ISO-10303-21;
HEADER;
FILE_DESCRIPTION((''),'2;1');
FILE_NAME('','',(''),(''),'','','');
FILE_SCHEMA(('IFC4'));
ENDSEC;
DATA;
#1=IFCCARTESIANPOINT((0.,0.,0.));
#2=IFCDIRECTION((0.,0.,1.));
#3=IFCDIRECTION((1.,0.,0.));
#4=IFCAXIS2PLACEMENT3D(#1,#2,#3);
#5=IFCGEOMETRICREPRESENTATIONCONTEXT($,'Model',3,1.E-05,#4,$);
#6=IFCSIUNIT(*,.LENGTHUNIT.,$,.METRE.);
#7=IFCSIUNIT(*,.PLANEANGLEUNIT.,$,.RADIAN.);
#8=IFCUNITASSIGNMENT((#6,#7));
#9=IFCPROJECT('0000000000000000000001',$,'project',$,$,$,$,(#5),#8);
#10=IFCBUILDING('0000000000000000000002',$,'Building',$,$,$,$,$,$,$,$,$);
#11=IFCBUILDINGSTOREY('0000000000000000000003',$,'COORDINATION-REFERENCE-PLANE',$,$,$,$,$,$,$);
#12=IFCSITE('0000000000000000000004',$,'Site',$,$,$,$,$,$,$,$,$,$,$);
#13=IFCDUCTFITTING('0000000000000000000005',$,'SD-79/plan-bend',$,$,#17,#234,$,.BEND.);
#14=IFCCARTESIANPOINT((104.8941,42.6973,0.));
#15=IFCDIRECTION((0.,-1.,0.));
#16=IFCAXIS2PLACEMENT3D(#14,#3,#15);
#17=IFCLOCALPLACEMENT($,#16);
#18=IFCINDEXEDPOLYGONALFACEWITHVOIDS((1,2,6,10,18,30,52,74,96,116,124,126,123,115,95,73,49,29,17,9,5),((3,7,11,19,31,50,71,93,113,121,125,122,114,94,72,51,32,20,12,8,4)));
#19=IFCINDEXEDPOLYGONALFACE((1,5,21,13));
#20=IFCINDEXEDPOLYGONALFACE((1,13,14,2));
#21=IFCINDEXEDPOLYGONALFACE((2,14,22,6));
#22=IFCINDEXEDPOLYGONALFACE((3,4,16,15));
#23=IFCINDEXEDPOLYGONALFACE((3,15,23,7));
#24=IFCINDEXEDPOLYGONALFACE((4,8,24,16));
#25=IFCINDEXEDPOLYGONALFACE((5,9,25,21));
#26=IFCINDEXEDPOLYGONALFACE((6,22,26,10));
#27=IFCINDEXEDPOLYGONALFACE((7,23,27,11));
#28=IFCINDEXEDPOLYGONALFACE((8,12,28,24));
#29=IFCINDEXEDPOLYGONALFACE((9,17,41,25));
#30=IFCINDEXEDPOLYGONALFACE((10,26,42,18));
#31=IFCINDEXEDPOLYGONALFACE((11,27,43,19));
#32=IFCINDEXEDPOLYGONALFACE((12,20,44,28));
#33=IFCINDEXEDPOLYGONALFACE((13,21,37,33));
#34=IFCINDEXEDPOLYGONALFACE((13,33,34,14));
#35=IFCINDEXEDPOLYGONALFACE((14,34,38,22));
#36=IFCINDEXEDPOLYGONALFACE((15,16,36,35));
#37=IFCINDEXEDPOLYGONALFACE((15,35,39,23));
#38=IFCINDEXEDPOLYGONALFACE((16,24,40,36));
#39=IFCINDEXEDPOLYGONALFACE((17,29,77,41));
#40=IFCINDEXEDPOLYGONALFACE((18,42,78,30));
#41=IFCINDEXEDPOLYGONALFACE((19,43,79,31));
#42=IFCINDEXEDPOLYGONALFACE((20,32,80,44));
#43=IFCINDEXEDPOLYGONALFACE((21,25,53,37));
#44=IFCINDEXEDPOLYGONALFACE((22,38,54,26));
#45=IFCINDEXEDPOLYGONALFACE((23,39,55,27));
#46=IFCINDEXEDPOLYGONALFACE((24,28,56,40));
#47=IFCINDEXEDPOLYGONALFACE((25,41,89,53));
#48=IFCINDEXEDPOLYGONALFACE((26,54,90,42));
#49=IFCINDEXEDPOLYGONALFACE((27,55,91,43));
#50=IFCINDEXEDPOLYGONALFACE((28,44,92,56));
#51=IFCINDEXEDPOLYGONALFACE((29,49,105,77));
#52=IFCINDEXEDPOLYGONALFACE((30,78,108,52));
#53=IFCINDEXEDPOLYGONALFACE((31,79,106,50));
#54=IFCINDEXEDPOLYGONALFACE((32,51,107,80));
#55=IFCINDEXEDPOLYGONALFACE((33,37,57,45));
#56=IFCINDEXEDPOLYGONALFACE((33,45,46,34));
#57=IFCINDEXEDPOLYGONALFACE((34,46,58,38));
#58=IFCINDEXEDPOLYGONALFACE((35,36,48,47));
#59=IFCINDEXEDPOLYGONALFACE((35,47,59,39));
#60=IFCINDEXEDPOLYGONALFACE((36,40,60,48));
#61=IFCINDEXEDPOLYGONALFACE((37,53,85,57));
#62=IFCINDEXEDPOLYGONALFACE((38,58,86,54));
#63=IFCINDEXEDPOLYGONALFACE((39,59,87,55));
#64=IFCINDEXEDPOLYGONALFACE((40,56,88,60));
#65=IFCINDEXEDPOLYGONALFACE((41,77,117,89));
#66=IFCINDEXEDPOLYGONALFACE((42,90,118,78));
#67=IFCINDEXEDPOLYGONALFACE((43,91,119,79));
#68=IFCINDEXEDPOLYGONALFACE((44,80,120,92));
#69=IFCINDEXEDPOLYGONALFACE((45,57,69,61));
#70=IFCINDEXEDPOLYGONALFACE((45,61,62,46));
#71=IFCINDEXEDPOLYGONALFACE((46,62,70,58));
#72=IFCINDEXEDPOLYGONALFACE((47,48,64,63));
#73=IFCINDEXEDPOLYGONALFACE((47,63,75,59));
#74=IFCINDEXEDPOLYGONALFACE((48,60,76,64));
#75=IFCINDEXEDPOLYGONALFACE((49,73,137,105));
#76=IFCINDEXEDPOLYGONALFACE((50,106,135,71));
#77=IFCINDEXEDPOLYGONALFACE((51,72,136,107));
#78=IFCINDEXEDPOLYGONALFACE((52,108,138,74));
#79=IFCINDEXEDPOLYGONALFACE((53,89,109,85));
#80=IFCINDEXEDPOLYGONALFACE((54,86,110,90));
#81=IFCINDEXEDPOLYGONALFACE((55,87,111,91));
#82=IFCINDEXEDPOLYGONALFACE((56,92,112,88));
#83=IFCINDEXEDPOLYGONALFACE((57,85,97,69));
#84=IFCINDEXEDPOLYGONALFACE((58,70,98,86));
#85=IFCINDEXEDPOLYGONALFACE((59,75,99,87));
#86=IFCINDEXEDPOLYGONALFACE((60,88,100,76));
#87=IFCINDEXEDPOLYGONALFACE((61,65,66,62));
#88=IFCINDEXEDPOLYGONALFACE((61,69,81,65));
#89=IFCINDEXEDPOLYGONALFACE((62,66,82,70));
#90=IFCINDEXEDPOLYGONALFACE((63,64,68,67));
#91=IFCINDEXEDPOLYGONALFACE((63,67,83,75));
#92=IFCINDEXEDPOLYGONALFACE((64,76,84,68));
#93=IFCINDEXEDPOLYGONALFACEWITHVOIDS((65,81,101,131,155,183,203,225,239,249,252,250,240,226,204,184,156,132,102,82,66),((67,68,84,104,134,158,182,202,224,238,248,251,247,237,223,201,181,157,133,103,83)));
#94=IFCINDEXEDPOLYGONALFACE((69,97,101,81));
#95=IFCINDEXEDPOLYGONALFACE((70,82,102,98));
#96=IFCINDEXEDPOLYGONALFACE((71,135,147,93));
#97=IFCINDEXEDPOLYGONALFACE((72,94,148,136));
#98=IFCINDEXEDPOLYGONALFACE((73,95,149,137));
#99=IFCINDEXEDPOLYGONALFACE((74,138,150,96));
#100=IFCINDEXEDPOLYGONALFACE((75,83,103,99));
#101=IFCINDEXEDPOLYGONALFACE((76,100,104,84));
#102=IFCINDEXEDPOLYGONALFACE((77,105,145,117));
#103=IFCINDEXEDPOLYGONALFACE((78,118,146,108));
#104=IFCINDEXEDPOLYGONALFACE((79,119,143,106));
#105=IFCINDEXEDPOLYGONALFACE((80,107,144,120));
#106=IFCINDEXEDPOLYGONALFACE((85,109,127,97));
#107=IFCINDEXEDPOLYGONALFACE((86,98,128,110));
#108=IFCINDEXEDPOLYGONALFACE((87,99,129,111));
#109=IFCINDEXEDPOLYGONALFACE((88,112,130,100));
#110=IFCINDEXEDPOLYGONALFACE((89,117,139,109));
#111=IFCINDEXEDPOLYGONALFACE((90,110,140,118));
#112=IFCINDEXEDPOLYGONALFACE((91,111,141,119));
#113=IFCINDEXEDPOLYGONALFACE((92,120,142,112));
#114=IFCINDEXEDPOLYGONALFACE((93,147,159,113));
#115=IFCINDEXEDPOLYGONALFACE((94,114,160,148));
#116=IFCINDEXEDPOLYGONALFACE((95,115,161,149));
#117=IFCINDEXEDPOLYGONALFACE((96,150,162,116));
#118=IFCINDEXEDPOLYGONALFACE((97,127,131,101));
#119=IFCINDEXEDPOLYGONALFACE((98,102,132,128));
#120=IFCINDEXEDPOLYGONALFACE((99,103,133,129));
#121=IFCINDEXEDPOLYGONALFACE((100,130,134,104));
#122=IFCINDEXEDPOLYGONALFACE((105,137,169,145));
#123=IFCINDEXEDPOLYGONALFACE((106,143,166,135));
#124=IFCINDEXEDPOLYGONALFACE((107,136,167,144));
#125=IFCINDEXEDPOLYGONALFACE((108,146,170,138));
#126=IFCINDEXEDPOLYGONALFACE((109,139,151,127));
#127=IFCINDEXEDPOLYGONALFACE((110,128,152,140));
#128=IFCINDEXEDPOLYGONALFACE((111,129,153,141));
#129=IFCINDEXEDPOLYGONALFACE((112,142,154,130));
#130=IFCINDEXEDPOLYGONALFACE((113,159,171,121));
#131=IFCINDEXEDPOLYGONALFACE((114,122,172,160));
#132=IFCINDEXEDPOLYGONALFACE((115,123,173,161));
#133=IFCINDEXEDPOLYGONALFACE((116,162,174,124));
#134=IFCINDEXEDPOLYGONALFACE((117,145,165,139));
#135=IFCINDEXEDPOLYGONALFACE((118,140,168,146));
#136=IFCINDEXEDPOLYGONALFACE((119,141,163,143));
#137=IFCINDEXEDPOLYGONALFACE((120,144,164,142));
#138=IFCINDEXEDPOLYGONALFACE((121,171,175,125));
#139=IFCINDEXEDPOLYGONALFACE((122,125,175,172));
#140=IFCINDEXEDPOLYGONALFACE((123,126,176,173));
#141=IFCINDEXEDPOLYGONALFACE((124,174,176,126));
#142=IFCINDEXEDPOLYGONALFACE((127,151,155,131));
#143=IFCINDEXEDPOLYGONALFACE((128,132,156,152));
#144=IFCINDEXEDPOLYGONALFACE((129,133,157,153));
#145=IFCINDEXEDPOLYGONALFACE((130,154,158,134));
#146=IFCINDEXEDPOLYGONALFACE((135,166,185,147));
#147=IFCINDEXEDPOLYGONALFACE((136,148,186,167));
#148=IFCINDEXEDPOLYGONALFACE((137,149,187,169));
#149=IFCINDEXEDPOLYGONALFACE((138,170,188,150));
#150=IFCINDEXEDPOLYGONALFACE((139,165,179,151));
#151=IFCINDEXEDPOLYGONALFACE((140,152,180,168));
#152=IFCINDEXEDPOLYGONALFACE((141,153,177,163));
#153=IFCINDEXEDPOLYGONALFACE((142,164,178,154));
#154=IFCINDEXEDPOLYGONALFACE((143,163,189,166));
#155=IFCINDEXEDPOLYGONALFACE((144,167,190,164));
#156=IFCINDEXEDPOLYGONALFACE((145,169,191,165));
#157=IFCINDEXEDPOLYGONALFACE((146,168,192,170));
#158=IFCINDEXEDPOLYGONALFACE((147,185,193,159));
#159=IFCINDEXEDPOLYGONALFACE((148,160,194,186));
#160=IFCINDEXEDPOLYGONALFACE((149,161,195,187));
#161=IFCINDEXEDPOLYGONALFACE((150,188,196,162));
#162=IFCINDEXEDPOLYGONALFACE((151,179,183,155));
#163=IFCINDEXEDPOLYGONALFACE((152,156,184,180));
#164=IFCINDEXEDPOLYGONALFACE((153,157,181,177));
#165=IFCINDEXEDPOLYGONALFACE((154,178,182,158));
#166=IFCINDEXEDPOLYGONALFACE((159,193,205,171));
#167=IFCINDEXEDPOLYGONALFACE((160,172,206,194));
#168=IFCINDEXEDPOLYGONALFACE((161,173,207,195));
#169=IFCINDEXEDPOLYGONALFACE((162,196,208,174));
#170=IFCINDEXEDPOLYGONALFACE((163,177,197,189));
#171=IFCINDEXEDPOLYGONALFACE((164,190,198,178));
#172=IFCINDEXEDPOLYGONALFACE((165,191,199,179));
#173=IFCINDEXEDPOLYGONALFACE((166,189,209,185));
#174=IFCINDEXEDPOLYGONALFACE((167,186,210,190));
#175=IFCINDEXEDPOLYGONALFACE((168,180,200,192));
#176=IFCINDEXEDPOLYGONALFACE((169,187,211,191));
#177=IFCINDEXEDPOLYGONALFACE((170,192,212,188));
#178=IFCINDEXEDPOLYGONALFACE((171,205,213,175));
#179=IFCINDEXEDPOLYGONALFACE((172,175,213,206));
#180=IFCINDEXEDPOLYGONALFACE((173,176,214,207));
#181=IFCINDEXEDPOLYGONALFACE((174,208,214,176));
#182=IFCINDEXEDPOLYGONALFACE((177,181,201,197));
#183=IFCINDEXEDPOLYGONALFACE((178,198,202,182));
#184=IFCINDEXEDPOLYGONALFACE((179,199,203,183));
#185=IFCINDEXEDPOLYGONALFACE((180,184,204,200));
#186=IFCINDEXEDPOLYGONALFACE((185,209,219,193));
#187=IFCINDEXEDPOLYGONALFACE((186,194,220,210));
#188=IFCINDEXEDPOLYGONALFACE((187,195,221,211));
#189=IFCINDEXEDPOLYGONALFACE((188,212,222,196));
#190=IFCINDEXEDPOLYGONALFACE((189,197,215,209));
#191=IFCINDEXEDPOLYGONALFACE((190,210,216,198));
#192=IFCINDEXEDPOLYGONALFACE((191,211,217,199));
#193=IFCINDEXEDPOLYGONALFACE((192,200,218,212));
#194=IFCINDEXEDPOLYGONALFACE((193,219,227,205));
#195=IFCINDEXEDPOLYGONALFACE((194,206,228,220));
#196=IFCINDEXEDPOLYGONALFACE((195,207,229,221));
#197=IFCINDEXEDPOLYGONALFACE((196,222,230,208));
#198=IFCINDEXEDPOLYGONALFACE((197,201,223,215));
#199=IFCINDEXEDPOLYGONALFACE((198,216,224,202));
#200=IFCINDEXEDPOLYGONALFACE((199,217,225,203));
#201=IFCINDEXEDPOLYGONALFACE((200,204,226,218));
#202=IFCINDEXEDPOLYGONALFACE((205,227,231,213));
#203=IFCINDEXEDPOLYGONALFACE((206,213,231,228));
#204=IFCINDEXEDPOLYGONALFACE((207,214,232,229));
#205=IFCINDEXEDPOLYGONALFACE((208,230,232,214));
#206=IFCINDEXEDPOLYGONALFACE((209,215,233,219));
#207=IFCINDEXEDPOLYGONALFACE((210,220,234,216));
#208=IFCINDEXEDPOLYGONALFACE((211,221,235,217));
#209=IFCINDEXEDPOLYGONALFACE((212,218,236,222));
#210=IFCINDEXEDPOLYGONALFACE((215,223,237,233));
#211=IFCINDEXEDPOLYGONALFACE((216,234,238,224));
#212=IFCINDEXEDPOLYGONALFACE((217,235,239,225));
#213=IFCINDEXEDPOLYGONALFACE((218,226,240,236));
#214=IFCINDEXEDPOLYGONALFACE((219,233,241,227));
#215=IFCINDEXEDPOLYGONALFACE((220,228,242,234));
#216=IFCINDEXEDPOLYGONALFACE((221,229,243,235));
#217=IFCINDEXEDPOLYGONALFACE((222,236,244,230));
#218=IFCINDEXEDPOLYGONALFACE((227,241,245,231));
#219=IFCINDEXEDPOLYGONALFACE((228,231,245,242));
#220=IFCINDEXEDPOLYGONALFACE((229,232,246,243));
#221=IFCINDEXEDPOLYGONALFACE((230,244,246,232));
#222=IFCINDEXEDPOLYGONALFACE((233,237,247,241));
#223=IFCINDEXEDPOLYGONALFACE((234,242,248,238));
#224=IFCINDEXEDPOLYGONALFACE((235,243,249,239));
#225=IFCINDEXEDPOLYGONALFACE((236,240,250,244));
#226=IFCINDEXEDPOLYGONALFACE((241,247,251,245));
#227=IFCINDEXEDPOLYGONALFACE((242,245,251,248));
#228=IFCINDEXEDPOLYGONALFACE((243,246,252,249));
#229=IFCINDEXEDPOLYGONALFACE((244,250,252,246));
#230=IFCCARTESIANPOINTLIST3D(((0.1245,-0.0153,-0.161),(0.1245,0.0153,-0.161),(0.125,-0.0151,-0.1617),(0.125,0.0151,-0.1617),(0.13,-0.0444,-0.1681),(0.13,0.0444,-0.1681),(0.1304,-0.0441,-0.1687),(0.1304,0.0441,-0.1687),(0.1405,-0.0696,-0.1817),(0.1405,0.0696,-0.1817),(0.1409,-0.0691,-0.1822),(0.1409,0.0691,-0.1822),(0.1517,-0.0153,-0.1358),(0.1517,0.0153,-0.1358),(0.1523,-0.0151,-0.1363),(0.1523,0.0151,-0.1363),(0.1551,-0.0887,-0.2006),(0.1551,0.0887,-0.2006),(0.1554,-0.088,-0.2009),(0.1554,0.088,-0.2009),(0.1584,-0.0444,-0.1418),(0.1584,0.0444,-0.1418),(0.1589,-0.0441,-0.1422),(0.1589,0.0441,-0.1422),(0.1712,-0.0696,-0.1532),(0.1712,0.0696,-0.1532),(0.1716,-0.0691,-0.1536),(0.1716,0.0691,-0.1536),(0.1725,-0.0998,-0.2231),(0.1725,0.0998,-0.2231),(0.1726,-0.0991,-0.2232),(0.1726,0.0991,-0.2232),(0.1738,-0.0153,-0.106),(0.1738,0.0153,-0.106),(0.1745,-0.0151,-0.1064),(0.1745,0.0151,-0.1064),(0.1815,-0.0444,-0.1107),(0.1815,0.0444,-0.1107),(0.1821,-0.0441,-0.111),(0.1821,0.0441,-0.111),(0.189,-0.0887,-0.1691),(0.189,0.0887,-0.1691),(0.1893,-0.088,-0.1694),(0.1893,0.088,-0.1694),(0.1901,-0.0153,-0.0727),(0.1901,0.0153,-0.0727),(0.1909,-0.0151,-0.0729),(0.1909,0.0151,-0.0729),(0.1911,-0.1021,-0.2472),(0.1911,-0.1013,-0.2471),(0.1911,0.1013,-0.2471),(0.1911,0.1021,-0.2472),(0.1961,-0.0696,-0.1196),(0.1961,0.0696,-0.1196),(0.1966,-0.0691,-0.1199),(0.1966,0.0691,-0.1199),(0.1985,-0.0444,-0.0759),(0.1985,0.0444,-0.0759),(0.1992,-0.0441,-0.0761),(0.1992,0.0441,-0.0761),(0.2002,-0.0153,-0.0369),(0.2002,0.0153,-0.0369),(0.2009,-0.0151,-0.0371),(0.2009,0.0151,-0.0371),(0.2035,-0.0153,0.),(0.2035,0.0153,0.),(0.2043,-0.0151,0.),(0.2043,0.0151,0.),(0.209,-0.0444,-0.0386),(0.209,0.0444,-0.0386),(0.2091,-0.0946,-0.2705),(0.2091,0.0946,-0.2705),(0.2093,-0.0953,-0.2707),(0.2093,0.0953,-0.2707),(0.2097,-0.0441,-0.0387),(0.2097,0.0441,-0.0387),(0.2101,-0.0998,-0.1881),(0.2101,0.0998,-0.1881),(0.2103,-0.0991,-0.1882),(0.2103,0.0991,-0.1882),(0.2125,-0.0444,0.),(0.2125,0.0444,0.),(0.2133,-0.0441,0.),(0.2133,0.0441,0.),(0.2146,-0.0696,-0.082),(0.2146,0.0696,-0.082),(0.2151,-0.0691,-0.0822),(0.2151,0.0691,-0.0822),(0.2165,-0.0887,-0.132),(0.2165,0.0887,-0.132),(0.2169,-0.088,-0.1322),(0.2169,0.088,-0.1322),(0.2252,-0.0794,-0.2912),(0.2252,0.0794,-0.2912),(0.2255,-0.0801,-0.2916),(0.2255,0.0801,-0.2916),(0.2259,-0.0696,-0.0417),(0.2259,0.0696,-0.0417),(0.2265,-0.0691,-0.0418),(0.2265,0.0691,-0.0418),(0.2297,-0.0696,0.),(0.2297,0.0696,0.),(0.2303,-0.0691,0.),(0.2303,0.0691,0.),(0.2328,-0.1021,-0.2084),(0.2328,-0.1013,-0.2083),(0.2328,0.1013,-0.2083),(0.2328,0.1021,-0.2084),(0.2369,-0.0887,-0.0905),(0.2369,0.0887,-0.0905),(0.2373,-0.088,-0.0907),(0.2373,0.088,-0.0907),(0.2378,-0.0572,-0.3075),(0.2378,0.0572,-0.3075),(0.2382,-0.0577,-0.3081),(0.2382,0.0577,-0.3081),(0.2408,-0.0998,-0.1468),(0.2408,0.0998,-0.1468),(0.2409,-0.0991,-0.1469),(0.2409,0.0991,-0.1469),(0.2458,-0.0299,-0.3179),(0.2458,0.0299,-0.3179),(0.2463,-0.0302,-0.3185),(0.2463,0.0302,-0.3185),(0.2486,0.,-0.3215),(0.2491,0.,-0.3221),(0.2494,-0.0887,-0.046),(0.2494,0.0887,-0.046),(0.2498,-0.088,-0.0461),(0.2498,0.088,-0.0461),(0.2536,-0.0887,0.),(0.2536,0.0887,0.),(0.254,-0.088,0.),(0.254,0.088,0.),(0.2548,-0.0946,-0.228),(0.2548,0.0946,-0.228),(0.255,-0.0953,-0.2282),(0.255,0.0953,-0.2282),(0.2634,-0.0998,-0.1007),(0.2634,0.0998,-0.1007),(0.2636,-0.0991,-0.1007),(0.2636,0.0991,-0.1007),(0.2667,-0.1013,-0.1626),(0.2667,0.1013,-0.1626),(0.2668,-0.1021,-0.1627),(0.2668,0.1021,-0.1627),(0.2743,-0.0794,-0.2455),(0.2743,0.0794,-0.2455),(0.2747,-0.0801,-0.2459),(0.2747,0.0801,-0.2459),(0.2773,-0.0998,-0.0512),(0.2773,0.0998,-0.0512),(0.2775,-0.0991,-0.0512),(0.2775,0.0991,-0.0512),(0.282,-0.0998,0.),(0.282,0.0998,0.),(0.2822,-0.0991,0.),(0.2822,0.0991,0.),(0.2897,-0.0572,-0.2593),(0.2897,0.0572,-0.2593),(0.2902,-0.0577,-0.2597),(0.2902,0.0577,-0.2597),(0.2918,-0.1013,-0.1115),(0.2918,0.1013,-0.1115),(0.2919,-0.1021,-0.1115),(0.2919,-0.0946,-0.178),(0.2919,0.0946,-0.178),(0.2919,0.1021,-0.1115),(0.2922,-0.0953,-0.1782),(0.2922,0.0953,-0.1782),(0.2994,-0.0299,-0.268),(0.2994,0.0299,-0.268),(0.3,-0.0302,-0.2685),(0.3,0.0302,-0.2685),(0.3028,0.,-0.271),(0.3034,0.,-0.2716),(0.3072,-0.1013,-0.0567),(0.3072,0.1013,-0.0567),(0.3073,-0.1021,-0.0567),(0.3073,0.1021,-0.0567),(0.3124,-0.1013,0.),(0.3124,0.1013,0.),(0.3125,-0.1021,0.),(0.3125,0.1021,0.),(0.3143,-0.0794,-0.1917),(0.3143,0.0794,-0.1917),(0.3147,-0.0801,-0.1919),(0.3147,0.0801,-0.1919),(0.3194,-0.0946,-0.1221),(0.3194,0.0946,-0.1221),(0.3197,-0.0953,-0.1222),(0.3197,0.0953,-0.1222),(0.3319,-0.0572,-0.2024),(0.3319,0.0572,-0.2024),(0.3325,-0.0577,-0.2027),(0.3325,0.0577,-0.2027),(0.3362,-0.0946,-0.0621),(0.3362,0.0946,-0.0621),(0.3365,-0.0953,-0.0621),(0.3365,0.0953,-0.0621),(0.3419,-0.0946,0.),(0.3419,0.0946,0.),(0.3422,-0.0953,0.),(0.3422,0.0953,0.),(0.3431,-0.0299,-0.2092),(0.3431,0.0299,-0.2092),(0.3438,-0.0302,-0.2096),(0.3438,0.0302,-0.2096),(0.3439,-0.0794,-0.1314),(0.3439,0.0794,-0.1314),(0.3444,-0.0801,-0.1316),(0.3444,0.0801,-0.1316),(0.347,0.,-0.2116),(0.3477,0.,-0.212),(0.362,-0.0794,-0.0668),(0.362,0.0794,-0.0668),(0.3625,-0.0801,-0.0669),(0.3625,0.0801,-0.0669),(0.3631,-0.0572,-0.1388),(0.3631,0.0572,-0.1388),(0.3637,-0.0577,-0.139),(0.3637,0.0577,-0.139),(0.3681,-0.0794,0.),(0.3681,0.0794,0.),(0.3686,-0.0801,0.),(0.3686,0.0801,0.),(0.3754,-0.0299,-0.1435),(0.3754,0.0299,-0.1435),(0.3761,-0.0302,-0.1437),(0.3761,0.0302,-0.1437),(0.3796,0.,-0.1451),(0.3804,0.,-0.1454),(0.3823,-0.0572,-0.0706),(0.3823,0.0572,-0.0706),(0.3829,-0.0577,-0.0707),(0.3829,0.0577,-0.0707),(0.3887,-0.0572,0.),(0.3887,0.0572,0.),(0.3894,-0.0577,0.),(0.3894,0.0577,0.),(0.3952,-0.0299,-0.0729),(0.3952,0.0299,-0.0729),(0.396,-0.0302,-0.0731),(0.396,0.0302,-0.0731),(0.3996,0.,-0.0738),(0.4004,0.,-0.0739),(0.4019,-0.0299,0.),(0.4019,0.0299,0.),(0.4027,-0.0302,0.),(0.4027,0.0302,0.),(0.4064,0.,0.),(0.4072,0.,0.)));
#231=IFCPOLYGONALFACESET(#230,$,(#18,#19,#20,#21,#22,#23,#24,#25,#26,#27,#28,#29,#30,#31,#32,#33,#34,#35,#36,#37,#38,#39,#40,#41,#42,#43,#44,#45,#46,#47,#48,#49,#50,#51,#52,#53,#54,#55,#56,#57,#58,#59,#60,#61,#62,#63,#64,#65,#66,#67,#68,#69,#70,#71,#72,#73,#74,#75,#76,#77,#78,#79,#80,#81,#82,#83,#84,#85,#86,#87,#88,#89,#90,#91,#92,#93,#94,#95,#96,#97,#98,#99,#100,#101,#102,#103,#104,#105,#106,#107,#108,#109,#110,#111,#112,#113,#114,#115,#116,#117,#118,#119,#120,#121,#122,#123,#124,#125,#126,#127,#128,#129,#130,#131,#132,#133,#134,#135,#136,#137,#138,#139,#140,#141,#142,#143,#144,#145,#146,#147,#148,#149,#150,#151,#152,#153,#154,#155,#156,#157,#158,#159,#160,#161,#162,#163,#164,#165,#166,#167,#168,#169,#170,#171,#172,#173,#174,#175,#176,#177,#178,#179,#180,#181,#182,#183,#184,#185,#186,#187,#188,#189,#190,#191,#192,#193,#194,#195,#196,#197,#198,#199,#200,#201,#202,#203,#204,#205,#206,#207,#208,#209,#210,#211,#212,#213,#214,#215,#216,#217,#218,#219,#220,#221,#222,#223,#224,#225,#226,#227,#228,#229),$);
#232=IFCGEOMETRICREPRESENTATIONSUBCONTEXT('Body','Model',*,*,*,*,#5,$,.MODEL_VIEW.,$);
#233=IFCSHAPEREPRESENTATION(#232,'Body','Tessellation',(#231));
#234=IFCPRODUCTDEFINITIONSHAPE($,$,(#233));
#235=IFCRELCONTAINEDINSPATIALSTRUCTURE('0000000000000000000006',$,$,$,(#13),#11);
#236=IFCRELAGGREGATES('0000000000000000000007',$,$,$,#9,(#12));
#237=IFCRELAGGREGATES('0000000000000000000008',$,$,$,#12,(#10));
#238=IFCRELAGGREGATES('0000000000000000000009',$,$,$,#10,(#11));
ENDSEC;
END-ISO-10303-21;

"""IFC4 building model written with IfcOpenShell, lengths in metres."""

from ifc_helpers import new_model, entity, si_unit, frame, origin_with_axes, place, context, subcontext, project, spatial, element, save


model = new_model("IFC4")

# Units and contexts
model_context = context("Model", 3, precision=1e-05, world=origin_with_axes())
body_context_1 = subcontext(model_context, "Body", "Model", "MODEL_VIEW")
ifc_project = project(units=[si_unit("LENGTHUNIT", "METRE"), si_unit("PLANEANGLEUNIT", "RADIAN")], contexts=[model_context])

# Site, building, storey
site = spatial("IfcSite", under=ifc_project, Name="Site")
building = spatial("IfcBuilding", under=site, Name="Building")
storey = spatial("IfcBuildingStorey", under=building, Name="COORDINATION-REFERENCE-PLANE")

# Duct fitting
duct_fitting_1_placement = place(None, frame((104.8941, 42.6973, 0.0), z_axis=(1.0, 0.0, 0.0), x_axis=(0.0, -1.0, 0.0)))
element("IfcDuctFitting", 1, at=duct_fitting_1_placement, inside=storey, Name="SD-79/plan-bend", PredefinedType="BEND", context=body_context_1, shape_type="SweptSolid", body=[
    entity("IfcRevolvedAreaSolid", entity("IfcCircleHollowProfileDef", "AREA", None, entity("IfcAxis2Placement2D", entity("IfcCartesianPoint", [0.3048, 0.0])), 0.1024, 0.0008), entity("IfcAxis2Placement3D", entity("IfcCartesianPoint", [0.0, 0.0, 0.0]), entity("IfcDirection", [0.0, 0.0, 1.0]), entity("IfcDirection", [1.0, 0.0, 0.0])), entity("IfcAxis1Placement", entity("IfcCartesianPoint", [0.0, 0.0, 0.0]), entity("IfcDirection", [0.0, 1.0, 0.0])), 0.912619),
])

save(model, "model.ifc")
